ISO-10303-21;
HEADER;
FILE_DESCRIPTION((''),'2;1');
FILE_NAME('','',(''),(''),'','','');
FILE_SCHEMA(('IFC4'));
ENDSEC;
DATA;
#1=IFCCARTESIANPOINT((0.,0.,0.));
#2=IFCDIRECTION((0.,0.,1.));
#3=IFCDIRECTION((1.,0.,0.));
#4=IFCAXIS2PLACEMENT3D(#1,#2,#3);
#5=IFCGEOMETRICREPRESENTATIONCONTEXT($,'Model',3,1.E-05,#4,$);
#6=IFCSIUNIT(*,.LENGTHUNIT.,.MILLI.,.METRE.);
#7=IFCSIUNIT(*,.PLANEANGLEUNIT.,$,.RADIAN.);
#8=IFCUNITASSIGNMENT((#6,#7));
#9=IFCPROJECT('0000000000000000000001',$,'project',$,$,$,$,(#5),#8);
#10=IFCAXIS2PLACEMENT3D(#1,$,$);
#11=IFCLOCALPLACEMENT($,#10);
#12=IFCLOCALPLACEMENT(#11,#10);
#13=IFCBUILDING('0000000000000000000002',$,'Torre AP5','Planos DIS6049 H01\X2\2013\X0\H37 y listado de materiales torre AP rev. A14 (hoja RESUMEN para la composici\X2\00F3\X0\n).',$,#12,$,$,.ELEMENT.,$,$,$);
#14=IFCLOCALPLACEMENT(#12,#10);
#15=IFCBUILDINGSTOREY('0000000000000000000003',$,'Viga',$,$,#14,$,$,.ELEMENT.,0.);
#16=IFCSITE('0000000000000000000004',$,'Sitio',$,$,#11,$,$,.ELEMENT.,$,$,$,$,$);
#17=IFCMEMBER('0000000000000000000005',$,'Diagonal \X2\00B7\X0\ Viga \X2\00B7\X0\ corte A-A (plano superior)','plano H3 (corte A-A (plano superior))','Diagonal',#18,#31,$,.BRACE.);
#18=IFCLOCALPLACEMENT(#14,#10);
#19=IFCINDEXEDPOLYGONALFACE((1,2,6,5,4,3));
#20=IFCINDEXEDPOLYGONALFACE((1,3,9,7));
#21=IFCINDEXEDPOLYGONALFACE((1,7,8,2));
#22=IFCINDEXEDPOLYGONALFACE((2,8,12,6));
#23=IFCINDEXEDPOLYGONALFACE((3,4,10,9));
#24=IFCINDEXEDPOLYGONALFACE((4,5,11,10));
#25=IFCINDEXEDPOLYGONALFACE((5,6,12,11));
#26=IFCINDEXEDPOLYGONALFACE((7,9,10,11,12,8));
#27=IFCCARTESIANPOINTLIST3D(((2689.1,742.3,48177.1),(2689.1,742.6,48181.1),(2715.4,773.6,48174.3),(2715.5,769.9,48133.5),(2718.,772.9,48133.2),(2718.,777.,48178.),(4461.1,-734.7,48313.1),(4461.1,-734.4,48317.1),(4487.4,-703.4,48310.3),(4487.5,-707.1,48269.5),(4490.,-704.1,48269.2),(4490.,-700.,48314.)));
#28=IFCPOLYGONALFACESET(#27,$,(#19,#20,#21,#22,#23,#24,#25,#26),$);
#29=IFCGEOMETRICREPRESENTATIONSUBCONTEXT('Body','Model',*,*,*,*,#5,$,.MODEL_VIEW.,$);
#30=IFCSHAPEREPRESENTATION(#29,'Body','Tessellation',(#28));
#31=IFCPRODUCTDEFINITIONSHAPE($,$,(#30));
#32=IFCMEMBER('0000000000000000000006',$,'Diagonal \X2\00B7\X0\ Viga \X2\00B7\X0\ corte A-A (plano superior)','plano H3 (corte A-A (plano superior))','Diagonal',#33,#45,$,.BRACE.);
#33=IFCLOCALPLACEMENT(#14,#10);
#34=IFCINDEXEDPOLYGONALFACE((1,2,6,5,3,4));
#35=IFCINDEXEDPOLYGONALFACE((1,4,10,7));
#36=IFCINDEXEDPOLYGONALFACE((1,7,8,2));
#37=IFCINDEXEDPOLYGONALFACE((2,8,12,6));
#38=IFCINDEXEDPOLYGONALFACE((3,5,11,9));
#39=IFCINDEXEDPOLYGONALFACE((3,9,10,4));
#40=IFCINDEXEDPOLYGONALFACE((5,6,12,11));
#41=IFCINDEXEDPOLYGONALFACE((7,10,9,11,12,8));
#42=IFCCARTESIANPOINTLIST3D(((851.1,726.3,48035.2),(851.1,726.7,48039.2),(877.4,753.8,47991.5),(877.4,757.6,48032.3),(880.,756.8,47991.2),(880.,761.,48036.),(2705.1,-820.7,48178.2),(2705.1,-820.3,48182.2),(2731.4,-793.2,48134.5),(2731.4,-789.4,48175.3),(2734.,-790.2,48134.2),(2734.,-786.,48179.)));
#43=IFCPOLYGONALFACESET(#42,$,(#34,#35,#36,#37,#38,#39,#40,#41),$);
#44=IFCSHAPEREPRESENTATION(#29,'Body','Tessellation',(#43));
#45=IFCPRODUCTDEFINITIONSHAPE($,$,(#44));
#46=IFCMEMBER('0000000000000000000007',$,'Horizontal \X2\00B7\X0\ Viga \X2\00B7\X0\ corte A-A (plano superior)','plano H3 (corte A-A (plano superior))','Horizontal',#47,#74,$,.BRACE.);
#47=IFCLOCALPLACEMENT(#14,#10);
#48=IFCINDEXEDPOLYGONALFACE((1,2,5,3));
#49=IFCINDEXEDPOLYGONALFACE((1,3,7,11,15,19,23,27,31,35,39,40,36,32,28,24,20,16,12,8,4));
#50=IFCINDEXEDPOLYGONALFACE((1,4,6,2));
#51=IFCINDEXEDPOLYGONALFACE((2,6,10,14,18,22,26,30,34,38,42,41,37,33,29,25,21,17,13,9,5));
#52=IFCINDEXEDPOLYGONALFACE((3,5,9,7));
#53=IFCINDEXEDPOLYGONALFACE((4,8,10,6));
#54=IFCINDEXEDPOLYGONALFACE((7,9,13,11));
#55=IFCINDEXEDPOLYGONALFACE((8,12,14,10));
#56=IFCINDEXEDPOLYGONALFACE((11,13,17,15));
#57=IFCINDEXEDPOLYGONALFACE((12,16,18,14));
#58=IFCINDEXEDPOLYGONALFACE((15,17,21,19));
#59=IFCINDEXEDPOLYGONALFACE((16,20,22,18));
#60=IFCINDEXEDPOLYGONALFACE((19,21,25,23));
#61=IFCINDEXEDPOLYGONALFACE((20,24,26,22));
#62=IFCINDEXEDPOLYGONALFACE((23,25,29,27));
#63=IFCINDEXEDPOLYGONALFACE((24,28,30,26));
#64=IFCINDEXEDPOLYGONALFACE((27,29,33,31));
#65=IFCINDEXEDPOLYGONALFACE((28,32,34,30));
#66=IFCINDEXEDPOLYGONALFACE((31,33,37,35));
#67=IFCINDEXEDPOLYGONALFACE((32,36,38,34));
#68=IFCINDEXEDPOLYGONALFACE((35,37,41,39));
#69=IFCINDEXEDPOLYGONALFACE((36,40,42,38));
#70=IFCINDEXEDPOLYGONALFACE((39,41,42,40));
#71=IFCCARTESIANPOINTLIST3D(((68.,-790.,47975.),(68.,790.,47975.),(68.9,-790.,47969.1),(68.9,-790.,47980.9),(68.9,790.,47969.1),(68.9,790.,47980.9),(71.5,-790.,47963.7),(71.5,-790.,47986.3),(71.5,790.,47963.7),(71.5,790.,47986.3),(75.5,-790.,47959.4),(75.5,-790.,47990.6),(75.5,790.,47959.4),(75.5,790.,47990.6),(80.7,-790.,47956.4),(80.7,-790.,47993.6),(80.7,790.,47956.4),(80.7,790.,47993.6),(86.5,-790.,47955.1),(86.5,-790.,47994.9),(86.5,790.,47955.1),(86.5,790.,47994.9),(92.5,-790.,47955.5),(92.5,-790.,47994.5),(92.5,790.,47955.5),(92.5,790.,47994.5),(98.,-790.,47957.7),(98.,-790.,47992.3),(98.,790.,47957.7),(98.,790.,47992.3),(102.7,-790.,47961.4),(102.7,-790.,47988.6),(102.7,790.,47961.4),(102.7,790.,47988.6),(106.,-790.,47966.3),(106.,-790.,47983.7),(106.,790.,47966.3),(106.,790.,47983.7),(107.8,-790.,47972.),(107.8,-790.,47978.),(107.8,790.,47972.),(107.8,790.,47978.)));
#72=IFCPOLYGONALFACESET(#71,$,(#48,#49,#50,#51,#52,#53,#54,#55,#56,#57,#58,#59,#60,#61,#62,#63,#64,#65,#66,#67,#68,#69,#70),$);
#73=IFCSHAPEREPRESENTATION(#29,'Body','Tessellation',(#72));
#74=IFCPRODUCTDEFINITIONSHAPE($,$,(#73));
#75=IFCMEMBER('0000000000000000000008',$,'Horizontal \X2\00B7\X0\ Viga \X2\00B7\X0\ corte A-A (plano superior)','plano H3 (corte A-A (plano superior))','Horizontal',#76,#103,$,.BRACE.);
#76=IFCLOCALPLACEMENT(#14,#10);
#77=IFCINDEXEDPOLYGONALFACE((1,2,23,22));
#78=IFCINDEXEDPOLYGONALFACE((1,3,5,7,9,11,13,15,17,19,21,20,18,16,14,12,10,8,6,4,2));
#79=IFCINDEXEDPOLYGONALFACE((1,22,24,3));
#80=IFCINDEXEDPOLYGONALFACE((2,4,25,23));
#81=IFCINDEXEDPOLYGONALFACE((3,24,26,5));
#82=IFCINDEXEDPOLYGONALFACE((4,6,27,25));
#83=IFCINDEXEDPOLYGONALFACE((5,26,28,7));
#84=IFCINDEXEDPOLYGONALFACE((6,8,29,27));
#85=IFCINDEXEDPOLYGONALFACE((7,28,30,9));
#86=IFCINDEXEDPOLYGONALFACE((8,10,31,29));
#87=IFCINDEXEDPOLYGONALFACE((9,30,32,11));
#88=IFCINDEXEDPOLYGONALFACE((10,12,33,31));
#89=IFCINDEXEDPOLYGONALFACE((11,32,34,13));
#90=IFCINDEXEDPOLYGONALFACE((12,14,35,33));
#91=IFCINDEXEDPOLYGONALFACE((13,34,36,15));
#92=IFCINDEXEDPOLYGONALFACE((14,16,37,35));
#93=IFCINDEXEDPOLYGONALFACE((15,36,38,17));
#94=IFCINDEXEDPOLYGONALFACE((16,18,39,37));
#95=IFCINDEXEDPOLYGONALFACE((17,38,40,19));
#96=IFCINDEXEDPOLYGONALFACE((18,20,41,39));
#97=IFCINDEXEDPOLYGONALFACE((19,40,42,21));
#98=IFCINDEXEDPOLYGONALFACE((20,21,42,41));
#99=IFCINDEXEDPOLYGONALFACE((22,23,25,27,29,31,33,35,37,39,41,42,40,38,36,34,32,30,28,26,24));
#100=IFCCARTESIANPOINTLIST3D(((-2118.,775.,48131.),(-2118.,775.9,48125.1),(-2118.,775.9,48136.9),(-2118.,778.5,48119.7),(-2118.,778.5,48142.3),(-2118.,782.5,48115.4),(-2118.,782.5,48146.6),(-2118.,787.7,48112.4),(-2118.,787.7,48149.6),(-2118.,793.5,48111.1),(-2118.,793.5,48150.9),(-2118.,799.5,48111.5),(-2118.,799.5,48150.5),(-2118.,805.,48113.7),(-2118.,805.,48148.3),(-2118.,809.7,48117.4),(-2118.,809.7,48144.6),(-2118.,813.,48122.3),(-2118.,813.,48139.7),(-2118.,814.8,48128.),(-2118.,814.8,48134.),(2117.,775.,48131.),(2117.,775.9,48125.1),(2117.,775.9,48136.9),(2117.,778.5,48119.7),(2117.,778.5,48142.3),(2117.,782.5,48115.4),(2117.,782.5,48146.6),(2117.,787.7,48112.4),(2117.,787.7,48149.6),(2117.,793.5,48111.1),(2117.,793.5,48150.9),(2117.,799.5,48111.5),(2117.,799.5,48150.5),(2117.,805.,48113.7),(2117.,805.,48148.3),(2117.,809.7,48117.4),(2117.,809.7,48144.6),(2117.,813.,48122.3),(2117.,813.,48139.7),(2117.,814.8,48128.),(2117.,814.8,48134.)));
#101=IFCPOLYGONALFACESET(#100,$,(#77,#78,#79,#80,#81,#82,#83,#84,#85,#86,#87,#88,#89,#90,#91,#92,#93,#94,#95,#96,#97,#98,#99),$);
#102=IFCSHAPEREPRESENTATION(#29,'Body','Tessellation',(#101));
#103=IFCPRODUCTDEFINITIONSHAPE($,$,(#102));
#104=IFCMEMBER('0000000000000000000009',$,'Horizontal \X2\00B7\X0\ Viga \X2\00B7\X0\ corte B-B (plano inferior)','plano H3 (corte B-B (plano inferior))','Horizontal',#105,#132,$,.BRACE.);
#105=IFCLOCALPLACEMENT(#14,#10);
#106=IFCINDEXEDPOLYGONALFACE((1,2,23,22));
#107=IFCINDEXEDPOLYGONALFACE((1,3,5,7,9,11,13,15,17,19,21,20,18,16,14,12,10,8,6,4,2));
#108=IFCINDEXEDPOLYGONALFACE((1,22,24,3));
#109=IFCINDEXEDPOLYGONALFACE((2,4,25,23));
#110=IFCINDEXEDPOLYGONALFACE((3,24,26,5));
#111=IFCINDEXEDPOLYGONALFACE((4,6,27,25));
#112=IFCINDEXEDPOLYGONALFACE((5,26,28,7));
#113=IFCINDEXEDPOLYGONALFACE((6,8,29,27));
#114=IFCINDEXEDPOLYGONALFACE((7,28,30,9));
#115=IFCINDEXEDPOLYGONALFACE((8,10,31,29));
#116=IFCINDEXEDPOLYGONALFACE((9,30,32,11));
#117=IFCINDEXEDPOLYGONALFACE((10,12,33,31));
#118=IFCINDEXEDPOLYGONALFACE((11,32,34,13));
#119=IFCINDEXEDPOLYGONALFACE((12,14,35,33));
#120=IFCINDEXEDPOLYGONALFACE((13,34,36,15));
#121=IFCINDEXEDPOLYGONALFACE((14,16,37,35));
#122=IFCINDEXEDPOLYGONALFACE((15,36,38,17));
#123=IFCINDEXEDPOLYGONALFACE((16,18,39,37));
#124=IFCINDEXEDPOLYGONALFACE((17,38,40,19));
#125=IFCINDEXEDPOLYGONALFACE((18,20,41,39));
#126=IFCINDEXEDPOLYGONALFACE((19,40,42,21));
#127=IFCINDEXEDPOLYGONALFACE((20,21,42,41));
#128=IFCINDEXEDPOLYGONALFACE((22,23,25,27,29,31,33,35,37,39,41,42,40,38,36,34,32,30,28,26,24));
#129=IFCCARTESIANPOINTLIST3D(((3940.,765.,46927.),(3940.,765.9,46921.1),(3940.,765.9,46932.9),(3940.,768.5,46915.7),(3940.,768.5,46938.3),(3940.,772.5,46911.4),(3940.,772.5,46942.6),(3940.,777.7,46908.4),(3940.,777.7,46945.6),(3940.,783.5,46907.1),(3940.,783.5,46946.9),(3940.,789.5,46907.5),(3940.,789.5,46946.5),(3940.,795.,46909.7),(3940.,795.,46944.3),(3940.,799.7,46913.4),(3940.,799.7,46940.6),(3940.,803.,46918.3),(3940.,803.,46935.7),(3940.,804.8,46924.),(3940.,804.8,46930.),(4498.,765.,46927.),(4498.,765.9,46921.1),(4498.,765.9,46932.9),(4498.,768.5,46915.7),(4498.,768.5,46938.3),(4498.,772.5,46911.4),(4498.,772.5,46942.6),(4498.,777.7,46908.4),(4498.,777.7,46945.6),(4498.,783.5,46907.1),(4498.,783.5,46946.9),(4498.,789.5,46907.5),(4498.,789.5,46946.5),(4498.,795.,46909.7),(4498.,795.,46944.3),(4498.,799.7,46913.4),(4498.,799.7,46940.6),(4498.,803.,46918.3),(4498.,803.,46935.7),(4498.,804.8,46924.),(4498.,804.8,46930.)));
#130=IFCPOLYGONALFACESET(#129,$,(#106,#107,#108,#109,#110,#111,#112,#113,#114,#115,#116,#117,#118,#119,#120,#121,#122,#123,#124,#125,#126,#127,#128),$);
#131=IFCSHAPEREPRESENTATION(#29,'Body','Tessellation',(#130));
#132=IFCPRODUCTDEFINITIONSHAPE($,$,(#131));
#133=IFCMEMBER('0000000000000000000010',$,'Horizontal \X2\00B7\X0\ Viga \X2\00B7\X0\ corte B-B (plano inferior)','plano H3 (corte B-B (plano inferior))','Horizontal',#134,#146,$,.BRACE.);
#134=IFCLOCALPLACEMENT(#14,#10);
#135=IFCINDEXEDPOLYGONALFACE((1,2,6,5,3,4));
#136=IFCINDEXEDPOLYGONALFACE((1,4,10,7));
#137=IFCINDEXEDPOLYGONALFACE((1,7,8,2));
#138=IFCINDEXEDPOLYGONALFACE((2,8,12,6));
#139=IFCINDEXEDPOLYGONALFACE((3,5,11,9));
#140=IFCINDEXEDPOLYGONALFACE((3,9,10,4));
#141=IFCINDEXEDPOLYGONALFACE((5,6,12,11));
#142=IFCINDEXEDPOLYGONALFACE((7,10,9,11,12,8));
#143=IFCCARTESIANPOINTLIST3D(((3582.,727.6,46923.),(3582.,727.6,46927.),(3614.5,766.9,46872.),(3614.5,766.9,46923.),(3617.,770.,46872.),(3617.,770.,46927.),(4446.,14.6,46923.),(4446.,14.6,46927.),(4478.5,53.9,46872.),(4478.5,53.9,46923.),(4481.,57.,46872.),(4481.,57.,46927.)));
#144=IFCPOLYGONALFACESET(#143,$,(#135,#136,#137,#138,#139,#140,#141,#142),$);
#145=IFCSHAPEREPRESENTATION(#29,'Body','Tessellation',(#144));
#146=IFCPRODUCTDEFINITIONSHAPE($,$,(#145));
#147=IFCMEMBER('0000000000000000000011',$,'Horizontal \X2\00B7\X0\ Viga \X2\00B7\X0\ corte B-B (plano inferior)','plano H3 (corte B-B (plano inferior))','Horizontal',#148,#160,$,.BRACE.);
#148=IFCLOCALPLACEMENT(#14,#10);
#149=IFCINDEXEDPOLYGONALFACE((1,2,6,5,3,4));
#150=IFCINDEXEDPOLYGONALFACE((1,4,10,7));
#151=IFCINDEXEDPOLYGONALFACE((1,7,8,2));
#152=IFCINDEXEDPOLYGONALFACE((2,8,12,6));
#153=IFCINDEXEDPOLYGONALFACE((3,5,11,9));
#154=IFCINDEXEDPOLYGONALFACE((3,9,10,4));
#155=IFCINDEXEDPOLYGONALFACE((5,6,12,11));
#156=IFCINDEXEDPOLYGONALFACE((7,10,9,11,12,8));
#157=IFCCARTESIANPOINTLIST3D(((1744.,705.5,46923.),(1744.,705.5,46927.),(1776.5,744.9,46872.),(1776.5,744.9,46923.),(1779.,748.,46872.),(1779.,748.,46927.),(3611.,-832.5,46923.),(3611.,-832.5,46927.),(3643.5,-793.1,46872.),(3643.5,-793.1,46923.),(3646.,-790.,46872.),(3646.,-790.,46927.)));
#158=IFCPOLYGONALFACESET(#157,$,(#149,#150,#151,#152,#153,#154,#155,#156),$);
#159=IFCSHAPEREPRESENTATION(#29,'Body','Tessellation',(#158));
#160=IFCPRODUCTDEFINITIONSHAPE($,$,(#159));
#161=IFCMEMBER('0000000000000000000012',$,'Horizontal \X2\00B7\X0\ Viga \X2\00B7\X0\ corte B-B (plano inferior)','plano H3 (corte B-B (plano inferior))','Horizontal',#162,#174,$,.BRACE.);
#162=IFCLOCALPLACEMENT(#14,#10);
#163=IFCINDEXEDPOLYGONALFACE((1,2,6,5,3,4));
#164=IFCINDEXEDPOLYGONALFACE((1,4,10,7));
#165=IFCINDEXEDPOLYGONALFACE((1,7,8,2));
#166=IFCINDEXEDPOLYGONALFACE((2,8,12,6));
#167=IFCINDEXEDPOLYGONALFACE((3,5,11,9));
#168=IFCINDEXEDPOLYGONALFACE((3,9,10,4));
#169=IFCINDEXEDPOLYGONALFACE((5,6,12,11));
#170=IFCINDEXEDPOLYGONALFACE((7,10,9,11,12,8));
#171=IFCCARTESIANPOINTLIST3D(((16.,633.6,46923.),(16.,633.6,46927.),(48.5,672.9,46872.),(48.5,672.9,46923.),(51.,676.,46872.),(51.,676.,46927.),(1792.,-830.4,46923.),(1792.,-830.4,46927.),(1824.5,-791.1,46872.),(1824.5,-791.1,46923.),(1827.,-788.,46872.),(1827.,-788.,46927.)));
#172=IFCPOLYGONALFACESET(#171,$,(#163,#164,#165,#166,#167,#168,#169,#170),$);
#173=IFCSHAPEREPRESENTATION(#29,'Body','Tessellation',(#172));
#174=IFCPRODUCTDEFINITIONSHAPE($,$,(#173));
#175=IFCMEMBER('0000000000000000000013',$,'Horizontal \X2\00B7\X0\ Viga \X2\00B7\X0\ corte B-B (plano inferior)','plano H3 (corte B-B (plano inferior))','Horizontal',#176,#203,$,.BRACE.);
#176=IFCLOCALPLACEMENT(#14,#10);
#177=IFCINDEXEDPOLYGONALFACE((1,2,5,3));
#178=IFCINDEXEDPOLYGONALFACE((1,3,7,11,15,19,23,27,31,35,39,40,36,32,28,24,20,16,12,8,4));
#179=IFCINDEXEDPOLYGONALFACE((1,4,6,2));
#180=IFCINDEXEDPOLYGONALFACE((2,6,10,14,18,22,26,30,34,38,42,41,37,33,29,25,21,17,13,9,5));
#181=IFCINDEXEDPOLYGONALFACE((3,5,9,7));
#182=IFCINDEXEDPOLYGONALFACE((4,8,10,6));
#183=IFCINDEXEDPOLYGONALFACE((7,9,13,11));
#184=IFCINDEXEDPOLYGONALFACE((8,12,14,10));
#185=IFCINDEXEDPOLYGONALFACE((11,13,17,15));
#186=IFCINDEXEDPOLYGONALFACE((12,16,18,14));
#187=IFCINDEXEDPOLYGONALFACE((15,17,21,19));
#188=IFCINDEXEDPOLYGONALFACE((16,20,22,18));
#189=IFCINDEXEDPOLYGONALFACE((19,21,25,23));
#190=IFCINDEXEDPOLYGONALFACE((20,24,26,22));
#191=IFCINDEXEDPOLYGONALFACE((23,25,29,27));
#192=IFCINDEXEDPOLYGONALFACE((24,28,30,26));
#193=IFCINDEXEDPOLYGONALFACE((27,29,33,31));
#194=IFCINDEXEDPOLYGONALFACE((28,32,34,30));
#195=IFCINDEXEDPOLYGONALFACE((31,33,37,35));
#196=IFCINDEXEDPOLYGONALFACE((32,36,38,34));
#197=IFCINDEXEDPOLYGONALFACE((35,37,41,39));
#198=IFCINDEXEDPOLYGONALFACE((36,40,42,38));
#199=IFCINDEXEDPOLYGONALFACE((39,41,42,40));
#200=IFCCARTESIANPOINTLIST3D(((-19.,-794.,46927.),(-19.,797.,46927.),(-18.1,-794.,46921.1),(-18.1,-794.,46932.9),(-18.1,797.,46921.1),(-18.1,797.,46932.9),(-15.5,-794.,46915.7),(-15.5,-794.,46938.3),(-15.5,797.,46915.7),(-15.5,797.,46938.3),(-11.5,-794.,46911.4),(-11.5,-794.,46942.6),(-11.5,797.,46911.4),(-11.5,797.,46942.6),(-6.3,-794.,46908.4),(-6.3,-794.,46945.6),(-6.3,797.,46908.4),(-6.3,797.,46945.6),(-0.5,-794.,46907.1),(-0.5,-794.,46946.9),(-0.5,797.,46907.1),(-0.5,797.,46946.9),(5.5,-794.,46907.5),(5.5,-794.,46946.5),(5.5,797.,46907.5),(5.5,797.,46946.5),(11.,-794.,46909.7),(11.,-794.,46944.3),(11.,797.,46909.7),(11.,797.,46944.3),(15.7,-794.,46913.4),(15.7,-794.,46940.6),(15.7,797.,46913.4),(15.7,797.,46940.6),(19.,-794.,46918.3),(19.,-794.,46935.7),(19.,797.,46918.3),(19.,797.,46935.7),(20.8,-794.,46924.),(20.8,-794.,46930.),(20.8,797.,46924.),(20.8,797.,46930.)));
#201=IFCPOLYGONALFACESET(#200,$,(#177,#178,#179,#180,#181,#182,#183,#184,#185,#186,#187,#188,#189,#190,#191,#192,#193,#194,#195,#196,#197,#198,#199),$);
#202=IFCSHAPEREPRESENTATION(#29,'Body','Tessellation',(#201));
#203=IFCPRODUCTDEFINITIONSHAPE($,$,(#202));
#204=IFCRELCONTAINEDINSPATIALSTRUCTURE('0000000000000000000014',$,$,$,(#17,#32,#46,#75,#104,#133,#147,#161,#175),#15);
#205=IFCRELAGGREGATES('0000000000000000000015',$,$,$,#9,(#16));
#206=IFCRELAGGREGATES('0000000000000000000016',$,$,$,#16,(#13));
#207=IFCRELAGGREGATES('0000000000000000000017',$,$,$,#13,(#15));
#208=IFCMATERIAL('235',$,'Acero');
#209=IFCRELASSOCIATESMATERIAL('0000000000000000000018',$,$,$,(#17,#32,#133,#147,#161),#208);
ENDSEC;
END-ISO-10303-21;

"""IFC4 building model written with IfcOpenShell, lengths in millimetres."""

from ifc_helpers import new_model, si_unit, frame, frame_2d, origin, origin_with_axes, place, context, subcontext, project, spatial, circle, l_section, extrude, material, element, save


model = new_model("IFC4")

# Units and contexts
model_context = context("Model", 3, precision=1e-05, world=origin_with_axes())
body_context = subcontext(model_context, "Body", "Model", "MODEL_VIEW")
ifc_project = project(units=[si_unit("LENGTHUNIT", "METRE", prefix="MILLI"), si_unit("PLANEANGLEUNIT", "RADIAN")], contexts=[model_context])

# Site, building, storey
site_placement = place(None, origin())
site = spatial("IfcSite", under=ifc_project, at=site_placement, Name="Sitio", CompositionType="ELEMENT")
building_placement = place(site_placement, origin())
building = spatial("IfcBuilding", under=site, at=building_placement, Name="Torre AP5", Description="Planos DIS6049 H01–H37 y listado de materiales torre AP rev. A14 (hoja RESUMEN para la composición).", CompositionType="ELEMENT")
storey_placement = place(building_placement, origin())
storey = spatial("IfcBuildingStorey", under=building, at=storey_placement, Name="Viga", CompositionType="ELEMENT", Elevation=0.0)

# Members
ifc_material = material(Name="235", Category="Acero")
member_1_placement = place(storey_placement, frame((2718.0, 777.0, 48178.0), z_axis=(0.766819, -0.63916, 0.058853), x_axis=(-0.641863, -0.763726, 0.06881)))
element("IfcMember", 1, at=member_1_placement, inside=storey, material=ifc_material, Name="Diagonal · Viga · corte A-A (plano superior)", Description="plano H3 (corte A-A (plano superior))", ObjectType="Diagonal", PredefinedType="BRACE", context=body_context, shape_type="SweptSolid", body=[
    extrude(l_section(Depth=45.0, Width=45.0, Thickness=4.0, at=frame_2d((22.5, 22.5))), None, (0.0, 0.0, 1.0), 2310.8),
])
member_2_placement = place(storey_placement, frame((880.0, 761.0, 48036.0), z_axis=(0.766471, -0.639553, 0.059118), x_axis=(-0.642279, -0.763125, 0.071545)))
element("IfcMember", 2, at=member_2_placement, inside=storey, material=ifc_material, Name="Diagonal · Viga · corte A-A (plano superior)", Description="plano H3 (corte A-A (plano superior))", ObjectType="Diagonal", PredefinedType="BRACE", context=body_context, shape_type="SweptSolid", body=[
    extrude(l_section(Depth=45.0, Width=45.0, Thickness=4.0, at=frame_2d((22.5, 22.5))), None, (0.0, 0.0, 1.0), 2418.9),
])
member_3_placement = place(storey_placement, frame((88.0, 790.0, 47975.0), z_axis=(0.0, -1.0, 0.0), x_axis=(-1.0, 0.0, 0.0)))
element("IfcMember", 3, at=member_3_placement, inside=storey, Name="Horizontal · Viga · corte A-A (plano superior)", Description="plano H3 (corte A-A (plano superior))", ObjectType="Horizontal", PredefinedType="BRACE", context=body_context, shape_type="SweptSolid", body=[
    extrude(circle(Radius=20.0), None, (0.0, 0.0, 1.0), 1580.0),
])
member_4_placement = place(storey_placement, frame((2117.0, 795.0, 48131.0), z_axis=(-1.0, 0.0, 0.0), x_axis=(0.0, -1.0, 0.0)))
element("IfcMember", 4, at=member_4_placement, inside=storey, Name="Horizontal · Viga · corte A-A (plano superior)", Description="plano H3 (corte A-A (plano superior))", ObjectType="Horizontal", PredefinedType="BRACE", context=body_context, shape_type="SweptSolid", body=[
    extrude(circle(Radius=20.0), None, (0.0, 0.0, 1.0), 4235.0),
])
member_5_placement = place(storey_placement, frame((3940.0, 785.0, 46927.0), z_axis=(1.0, 0.0, 0.0), x_axis=(0.0, -1.0, 0.0)))
element("IfcMember", 5, at=member_5_placement, inside=storey, Name="Horizontal · Viga · corte B-B (plano inferior)", Description="plano H3 (corte B-B (plano inferior))", ObjectType="Horizontal", PredefinedType="BRACE", context=body_context, shape_type="SweptSolid", body=[
    extrude(circle(Radius=20.0), None, (0.0, 0.0, 1.0), 558.0),
])
member_6_placement = place(storey_placement, frame((3617.0, 770.0, 46927.0), z_axis=(0.771286, -0.636489, 0.0), x_axis=(-0.636489, -0.771286, 0.0)))
element("IfcMember", 6, at=member_6_placement, inside=storey, material=ifc_material, Name="Horizontal · Viga · corte B-B (plano inferior)", Description="plano H3 (corte B-B (plano inferior))", ObjectType="Horizontal", PredefinedType="BRACE", context=body_context, shape_type="SweptSolid", body=[
    extrude(l_section(Depth=55.0, Width=55.0, Thickness=4.0, at=frame_2d((27.5, 27.5))), None, (0.0, 0.0, 1.0), 1120.2),
])
member_7_placement = place(storey_placement, frame((1779.0, 748.0, 46927.0), z_axis=(0.771835, -0.635823, 0.0), x_axis=(-0.635823, -0.771835, 0.0)))
element("IfcMember", 7, at=member_7_placement, inside=storey, material=ifc_material, Name="Horizontal · Viga · corte B-B (plano inferior)", Description="plano H3 (corte B-B (plano inferior))", ObjectType="Horizontal", PredefinedType="BRACE", context=body_context, shape_type="SweptSolid", body=[
    extrude(l_section(Depth=55.0, Width=55.0, Thickness=4.0, at=frame_2d((27.5, 27.5))), None, (0.0, 0.0, 1.0), 2418.9),
])
member_8_placement = place(storey_placement, frame((51.0, 676.0, 46927.0), z_axis=(0.771629, -0.636073, 0.0), x_axis=(-0.636073, -0.771629, 0.0)))
element("IfcMember", 8, at=member_8_placement, inside=storey, material=ifc_material, Name="Horizontal · Viga · corte B-B (plano inferior)", Description="plano H3 (corte B-B (plano inferior))", ObjectType="Horizontal", PredefinedType="BRACE", context=body_context, shape_type="SweptSolid", body=[
    extrude(l_section(Depth=55.0, Width=55.0, Thickness=4.0, at=frame_2d((27.5, 27.5))), None, (0.0, 0.0, 1.0), 2301.6),
])
member_9_placement = place(storey_placement, frame((1.0, 797.0, 46927.0), z_axis=(0.0, -1.0, 0.0), x_axis=(-1.0, 0.0, 0.0)))
element("IfcMember", 9, at=member_9_placement, inside=storey, Name="Horizontal · Viga · corte B-B (plano inferior)", Description="plano H3 (corte B-B (plano inferior))", ObjectType="Horizontal", PredefinedType="BRACE", context=body_context, shape_type="SweptSolid", body=[
    extrude(circle(Radius=20.0), None, (0.0, 0.0, 1.0), 1591.0),
])

save(model, "model.ifc")
